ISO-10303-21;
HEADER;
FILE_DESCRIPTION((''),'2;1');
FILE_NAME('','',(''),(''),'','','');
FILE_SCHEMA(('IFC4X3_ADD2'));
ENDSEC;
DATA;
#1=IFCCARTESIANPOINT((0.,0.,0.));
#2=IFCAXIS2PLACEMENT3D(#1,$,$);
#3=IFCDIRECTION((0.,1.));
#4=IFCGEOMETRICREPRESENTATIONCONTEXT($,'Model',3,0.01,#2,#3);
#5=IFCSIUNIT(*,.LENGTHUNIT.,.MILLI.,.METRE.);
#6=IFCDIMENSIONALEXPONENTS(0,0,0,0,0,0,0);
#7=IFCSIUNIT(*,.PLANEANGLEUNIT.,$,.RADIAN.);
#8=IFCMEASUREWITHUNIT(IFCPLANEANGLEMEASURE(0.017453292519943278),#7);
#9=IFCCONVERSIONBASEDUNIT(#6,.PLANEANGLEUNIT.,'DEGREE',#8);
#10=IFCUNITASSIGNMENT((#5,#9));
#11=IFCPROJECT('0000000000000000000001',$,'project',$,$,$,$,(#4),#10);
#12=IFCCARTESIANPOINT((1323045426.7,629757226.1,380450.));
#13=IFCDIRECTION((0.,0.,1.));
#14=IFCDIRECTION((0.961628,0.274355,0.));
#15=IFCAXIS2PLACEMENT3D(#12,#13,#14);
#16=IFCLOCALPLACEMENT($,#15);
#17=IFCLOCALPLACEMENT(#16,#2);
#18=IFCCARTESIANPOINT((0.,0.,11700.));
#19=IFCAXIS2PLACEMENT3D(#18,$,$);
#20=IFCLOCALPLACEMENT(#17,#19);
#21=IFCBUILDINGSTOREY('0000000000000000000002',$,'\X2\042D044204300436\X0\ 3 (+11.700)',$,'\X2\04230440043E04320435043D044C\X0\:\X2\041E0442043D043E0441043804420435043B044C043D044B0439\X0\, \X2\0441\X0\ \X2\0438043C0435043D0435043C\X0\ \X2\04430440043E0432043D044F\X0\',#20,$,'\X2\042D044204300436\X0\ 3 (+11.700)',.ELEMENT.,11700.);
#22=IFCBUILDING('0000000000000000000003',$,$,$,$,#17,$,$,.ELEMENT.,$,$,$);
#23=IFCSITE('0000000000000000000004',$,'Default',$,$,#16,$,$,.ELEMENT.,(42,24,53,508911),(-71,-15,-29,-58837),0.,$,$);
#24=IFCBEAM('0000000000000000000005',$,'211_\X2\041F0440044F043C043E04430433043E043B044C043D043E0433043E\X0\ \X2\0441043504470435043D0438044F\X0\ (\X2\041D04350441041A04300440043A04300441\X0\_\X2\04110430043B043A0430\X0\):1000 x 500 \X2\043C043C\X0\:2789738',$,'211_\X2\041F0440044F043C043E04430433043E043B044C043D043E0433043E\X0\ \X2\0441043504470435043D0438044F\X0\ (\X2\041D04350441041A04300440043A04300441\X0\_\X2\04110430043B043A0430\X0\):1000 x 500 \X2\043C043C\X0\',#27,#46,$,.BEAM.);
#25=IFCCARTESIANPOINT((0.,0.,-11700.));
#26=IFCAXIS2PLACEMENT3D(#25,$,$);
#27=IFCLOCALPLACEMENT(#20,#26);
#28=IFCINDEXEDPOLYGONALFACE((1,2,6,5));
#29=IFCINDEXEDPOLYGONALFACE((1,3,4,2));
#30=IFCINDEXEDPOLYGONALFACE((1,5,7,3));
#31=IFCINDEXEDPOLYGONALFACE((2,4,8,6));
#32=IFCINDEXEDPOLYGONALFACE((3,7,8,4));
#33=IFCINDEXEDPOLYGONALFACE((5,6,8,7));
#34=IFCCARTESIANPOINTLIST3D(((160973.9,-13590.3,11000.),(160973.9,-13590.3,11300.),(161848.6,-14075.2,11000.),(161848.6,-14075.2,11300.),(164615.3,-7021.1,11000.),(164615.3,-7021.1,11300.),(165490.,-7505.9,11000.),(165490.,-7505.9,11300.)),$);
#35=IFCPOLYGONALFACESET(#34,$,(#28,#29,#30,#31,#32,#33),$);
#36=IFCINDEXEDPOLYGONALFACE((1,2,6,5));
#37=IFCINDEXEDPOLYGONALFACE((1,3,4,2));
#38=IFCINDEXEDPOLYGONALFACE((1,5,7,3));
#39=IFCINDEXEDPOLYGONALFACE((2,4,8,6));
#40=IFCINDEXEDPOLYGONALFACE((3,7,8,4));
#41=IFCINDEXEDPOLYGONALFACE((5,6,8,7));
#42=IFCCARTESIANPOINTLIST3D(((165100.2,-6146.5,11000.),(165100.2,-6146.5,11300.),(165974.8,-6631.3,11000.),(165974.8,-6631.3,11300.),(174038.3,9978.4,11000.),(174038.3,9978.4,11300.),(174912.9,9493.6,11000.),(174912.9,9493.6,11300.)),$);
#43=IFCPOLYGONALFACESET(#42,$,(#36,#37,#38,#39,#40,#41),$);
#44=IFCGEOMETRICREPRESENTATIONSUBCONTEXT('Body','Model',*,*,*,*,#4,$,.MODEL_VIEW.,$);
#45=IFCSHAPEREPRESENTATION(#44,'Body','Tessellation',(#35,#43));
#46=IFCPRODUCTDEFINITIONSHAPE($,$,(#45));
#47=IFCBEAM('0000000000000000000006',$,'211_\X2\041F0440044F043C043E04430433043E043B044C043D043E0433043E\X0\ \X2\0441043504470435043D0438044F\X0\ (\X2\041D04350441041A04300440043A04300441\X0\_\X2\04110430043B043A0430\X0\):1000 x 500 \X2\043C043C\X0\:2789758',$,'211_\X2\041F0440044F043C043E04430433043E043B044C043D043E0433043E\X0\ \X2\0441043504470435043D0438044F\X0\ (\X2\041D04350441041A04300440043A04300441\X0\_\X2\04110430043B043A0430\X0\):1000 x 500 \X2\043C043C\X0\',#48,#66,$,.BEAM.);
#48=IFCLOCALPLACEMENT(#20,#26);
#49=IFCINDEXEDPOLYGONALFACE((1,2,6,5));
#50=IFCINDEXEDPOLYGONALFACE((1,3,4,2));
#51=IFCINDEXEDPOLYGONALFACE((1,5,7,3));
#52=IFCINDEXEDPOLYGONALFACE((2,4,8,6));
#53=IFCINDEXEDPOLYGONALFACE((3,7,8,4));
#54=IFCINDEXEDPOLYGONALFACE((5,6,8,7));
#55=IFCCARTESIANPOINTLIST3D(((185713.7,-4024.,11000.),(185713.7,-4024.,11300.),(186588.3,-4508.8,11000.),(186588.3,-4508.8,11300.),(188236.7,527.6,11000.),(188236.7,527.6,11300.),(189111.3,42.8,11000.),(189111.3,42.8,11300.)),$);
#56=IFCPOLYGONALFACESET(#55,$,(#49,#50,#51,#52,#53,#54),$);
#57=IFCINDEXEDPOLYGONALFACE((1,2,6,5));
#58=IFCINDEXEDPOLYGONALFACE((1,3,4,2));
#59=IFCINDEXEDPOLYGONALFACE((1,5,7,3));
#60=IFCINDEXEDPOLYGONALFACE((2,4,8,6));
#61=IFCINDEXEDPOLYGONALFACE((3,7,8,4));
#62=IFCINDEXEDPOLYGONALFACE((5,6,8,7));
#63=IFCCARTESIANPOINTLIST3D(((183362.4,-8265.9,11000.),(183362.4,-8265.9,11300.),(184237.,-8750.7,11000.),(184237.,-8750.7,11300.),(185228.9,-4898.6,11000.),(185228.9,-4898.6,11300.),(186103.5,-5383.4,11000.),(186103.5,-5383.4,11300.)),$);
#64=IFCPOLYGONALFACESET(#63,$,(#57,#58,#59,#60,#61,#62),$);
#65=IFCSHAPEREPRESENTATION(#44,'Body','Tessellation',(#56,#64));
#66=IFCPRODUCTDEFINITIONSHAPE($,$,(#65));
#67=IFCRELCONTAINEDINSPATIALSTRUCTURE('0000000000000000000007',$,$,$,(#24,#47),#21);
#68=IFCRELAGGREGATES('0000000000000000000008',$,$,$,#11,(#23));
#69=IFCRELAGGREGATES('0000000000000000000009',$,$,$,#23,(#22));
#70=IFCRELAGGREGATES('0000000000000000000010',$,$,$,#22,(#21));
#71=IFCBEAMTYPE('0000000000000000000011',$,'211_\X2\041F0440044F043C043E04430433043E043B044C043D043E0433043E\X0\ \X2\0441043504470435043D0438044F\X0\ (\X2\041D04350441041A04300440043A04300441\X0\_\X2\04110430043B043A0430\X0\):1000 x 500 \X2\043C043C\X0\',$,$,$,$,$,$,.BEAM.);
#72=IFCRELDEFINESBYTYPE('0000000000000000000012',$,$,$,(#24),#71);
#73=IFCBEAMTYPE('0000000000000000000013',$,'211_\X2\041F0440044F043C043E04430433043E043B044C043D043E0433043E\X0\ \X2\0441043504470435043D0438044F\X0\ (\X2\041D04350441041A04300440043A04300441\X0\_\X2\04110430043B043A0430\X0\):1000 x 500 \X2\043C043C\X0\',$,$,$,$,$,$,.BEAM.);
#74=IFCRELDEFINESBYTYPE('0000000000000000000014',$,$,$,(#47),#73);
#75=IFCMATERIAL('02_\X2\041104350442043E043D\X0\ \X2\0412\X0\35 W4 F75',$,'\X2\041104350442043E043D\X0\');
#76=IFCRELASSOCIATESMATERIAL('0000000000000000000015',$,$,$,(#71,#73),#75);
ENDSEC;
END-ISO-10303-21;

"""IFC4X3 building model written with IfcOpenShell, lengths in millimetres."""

from ifc_helpers import new_model, entity, si_unit, converted_unit, direction, frame, frame_2d, origin, place, context, subcontext, project, spatial, polyline, segment, composite_curve, rectangle, outline, extrude, source, transform, mapped, material, material_profile, profile_set, type_object, type_shapes, element, save


model = new_model("IFC4X3")

# Units and contexts
model_context = context("Model", 3, precision=0.01, world=origin(), true_north=direction((0.0, 1.0)))
body_context = subcontext(model_context, "Body", "Model", "MODEL_VIEW")
ifc_project = project(units=[si_unit("LENGTHUNIT", "METRE", prefix="MILLI"), converted_unit("PLANEANGLEUNIT", "DEGREE", entity("IfcPlaneAngleMeasure", 0.017453292519943278), si_unit("PLANEANGLEUNIT", "RADIAN"), dimensions=[0, 0, 0, 0, 0, 0, 0])], contexts=[model_context])

# Site, building, storey
site_placement = place(None, frame((1323045426.7, 629757226.1, 380450.0), z_axis=(0.0, 0.0, 1.0), x_axis=(0.961628, 0.274355, 0.0)))
site = spatial("IfcSite", under=ifc_project, at=site_placement, Name="Default", CompositionType="ELEMENT", RefLatitude=(42, 24, 53, 508911), RefLongitude=(-71, -15, -29, -58837), RefElevation=0.0)
building_placement = place(site_placement, origin())
building = spatial("IfcBuilding", under=site, at=building_placement, CompositionType="ELEMENT")
storey_placement = place(building_placement, frame((0.0, 0.0, 11700.0)))
storey = spatial("IfcBuildingStorey", under=building, at=storey_placement, Name="Этаж 3 (+11.700)", ObjectType="Уровень:Относительный, с именем уровня", LongName="Этаж 3 (+11.700)", CompositionType="ELEMENT", Elevation=11700.0)

# Beams
ifc_material = material(Name="02_Бетон В35 W4 F75", Category="Бетон")
ifc_material_profile_1 = material_profile(ifc_material, outline(composite_curve([segment(polyline([(-500.0, 50.0, 0.0), (500.0, 50.0, 0.0)]), True, "CONTINUOUS"), segment(polyline([(500.0, 50.0, 0.0), (500.0, -250.0, 0.0)]), True, "CONTINUOUS"), segment(polyline([(500.0, -250.0, 0.0), (-500.0, -250.0, 0.0)]), True, "CONTINUOUS"), segment(polyline([(-500.0, -250.0, 0.0), (-500.0, 50.0, 0.0)]), True, "CONTINUOUS")], self_intersect=False), kind="CURVE"), Name="1000 x 500 мм")
ifc_profile_set_1 = profile_set([ifc_material_profile_1], Name="1000 x 500 мм")
beam_type_1 = type_object("IfcBeamType", Name="211_Прямоугольного сечения (НесКаркас_Балка):1000 x 500 мм", PredefinedType="BEAM", material=ifc_profile_set_1)
shared_shape_1 = source(origin(), body_context, "Body", "SweptSolid", [
    extrude(rectangle(XDim=300.0, YDim=1000.0, at=frame_2d((0.0, 0.0), x_axis=(1.0, 0.0))), frame((165052.7, -7263.5, 11150.0), z_axis=(-0.48481, -0.87462, 0.0), x_axis=(0.0, 0.0, -1.0)), (0.0, 0.0, 1.0), 7511.0),
    extrude(rectangle(XDim=300.0, YDim=1000.0, at=frame_2d((0.0, 0.0), x_axis=(1.0, 0.0))), frame((174475.6, 9736.0, 11150.0), z_axis=(-0.48481, -0.87462, 0.0), x_axis=(0.0, 0.0, -1.0)), (0.0, 0.0, 1.0), 18436.4),
])
type_shapes(beam_type_1, [shared_shape_1])
beam_1_placement = place(storey_placement, frame((0.0, 0.0, -11700.0)))
element("IfcBeam", 1, at=beam_1_placement, inside=storey, type_object=beam_type_1, Name="211_Прямоугольного сечения (НесКаркас_Балка):1000 x 500 мм:2789738", ObjectType="211_Прямоугольного сечения (НесКаркас_Балка):1000 x 500 мм", PredefinedType="BEAM", context=body_context, shape_type="MappedRepresentation", body=[
    mapped(shared_shape_1, transform((0.0, 0.0, 0.0), scale=1.0)),
])
beam_type_2 = type_object("IfcBeamType", Name="211_Прямоугольного сечения (НесКаркас_Балка):1000 x 500 мм", PredefinedType="BEAM", material=ifc_profile_set_1)
shared_shape_2 = source(origin(), body_context, "Body", "SweptSolid", [
    extrude(rectangle(XDim=300.0, YDim=1000.0, at=frame_2d((0.0, 0.0), x_axis=(1.0, 0.0))), frame((188674.0, 285.2, 11150.0), z_axis=(-0.48481, -0.87462, 0.0), x_axis=(0.0, 0.0, -1.0)), (0.0, 0.0, 1.0), 5204.1),
    extrude(rectangle(XDim=300.0, YDim=1000.0, at=frame_2d((0.0, 0.0), x_axis=(1.0, 0.0))), frame((185666.2, -5141.0, 11150.0), z_axis=(-0.48481, -0.87462, 0.0), x_axis=(0.0, 0.0, -1.0)), (0.0, 0.0, 1.0), 3850.0),
])
type_shapes(beam_type_2, [shared_shape_2])
beam_2_placement = place(storey_placement, frame((0.0, 0.0, -11700.0)))
element("IfcBeam", 2, at=beam_2_placement, inside=storey, type_object=beam_type_2, Name="211_Прямоугольного сечения (НесКаркас_Балка):1000 x 500 мм:2789758", ObjectType="211_Прямоугольного сечения (НесКаркас_Балка):1000 x 500 мм", PredefinedType="BEAM", context=body_context, shape_type="MappedRepresentation", body=[
    mapped(shared_shape_2, transform((0.0, 0.0, 0.0), scale=1.0)),
])

save(model, "model.ifc")
